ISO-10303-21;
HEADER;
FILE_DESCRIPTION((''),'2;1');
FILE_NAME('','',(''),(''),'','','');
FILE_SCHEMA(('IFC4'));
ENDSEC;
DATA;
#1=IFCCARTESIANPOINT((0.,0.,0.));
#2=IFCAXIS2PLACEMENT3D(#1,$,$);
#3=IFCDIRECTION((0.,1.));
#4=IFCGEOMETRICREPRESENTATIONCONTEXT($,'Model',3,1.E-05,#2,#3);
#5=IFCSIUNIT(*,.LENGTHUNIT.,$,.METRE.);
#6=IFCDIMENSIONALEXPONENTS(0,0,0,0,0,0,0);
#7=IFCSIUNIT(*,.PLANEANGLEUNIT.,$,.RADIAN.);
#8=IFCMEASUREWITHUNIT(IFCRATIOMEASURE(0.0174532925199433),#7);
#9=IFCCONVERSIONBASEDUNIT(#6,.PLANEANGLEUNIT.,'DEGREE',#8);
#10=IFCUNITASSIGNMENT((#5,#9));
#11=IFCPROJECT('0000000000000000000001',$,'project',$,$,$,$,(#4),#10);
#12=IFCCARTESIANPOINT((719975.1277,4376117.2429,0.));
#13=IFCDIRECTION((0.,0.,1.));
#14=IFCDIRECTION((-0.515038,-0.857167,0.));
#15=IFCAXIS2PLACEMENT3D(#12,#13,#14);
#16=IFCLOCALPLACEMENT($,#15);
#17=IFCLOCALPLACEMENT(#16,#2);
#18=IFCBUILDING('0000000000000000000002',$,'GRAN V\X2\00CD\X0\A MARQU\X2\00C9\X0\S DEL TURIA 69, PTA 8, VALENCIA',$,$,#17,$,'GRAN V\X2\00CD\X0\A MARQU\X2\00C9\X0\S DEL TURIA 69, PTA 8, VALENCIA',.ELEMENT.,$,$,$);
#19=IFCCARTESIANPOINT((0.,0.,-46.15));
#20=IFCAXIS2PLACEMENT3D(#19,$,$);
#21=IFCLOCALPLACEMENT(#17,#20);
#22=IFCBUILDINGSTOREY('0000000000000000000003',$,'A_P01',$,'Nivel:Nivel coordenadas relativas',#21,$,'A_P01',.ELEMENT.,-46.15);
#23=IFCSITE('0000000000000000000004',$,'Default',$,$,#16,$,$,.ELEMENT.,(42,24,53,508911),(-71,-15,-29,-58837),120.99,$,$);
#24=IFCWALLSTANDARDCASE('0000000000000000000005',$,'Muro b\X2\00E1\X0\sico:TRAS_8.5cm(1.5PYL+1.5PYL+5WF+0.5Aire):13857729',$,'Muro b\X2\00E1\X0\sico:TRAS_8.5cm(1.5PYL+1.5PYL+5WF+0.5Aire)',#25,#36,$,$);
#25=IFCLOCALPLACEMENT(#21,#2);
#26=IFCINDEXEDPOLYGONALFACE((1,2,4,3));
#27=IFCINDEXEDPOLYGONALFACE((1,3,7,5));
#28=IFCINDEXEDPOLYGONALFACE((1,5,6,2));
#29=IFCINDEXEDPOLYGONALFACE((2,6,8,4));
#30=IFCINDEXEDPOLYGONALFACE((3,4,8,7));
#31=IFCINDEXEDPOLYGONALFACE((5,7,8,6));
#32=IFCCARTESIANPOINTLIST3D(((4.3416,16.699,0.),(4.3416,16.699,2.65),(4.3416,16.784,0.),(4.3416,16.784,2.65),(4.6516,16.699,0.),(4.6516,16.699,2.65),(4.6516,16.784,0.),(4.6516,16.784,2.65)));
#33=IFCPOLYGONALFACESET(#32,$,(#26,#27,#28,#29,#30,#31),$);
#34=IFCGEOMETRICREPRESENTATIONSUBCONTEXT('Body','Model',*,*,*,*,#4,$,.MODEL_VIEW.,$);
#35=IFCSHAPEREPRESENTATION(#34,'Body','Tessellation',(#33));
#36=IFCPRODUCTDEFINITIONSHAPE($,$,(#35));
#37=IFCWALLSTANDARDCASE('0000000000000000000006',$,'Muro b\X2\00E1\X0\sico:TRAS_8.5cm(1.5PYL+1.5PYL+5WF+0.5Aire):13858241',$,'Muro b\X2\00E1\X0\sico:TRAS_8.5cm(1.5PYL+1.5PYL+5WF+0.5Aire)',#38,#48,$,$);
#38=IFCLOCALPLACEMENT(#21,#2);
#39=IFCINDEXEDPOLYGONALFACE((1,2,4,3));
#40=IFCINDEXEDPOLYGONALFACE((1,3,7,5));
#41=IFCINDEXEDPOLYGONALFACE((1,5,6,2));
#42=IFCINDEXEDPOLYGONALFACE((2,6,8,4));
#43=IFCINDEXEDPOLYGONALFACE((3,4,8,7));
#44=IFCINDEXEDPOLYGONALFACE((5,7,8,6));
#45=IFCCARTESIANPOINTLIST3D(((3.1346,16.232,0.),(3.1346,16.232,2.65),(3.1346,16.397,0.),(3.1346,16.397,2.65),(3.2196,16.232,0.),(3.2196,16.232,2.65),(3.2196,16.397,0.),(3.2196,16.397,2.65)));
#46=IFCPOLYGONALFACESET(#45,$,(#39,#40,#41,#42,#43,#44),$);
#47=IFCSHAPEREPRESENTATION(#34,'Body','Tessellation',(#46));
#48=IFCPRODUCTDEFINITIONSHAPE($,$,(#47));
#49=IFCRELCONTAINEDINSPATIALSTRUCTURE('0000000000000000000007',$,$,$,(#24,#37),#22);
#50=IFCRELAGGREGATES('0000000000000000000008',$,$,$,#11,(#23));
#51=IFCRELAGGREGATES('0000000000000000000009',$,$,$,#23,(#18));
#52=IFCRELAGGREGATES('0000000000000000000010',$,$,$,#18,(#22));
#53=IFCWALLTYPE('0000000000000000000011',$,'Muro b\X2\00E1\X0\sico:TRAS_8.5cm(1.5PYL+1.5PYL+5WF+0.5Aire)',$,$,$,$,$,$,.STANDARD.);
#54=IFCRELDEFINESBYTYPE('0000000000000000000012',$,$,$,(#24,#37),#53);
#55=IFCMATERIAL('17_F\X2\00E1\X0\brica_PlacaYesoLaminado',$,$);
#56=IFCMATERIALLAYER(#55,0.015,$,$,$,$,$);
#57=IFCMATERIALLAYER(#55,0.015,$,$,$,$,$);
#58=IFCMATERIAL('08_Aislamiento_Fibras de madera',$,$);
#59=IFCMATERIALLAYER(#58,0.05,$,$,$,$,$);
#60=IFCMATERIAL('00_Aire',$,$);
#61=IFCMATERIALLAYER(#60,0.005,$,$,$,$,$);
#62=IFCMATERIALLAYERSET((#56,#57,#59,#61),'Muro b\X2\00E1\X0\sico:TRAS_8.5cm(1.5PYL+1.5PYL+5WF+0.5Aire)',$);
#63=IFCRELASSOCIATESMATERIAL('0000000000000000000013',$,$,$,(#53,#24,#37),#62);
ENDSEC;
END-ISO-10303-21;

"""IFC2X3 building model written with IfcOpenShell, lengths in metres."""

from ifc_helpers import new_model, entity, si_unit, converted_unit, direction, frame, frame_2d, origin, place, context, subcontext, project, spatial, rectangle, extrude, material, layer, layer_set, layer_usage, type_object, element, save


model = new_model("IFC2X3")

# Units and contexts
model_context = context("Model", 3, precision=1e-05, world=origin(), true_north=direction((0.0, 1.0)))
body_context = subcontext(model_context, "Body", "Model", "MODEL_VIEW")
ifc_project = project(units=[si_unit("LENGTHUNIT", "METRE"), converted_unit("PLANEANGLEUNIT", "DEGREE", entity("IfcRatioMeasure", 0.0174532925199433), si_unit("PLANEANGLEUNIT", "RADIAN"), dimensions=[0, 0, 0, 0, 0, 0, 0])], contexts=[model_context])

# Site, building, storey
site_placement = place(None, frame((719975.1277, 4376117.2429, 0.0), z_axis=(0.0, 0.0, 1.0), x_axis=(-0.515038, -0.857167, 0.0)))
site = spatial("IfcSite", under=ifc_project, at=site_placement, Name="Default", CompositionType="ELEMENT", RefLatitude=(42, 24, 53, 508911), RefLongitude=(-71, -15, -29, -58837), RefElevation=120.99)
building_placement = place(site_placement, origin())
building = spatial("IfcBuilding", under=site, at=building_placement, Name="GRAN VÍA MARQUÉS DEL TURIA 69, PTA 8, VALENCIA", LongName="GRAN VÍA MARQUÉS DEL TURIA 69, PTA 8, VALENCIA", CompositionType="ELEMENT")
storey_placement = place(building_placement, frame((0.0, 0.0, -46.15)))
storey = spatial("IfcBuildingStorey", under=building, at=storey_placement, Name="A_P01", ObjectType="Nivel:Nivel coordenadas relativas", LongName="A_P01", CompositionType="ELEMENT", Elevation=-46.15)

# Shared definitions
ifc_material_1 = material(Name="08_Aislamiento_Fibras de madera")

# Walls
ifc_material_2 = material(Name="17_Fábrica_PlacaYesoLaminado")
ifc_layer_1 = layer(ifc_material_2, 0.015)
ifc_layer_2 = layer(ifc_material_2, 0.015)
ifc_layer_3 = layer(ifc_material_1, 0.05)
ifc_material_3 = material(Name="00_Aire")
ifc_layer_4 = layer(ifc_material_3, 0.005)
ifc_layer_set_1 = layer_set([ifc_layer_1, ifc_layer_2, ifc_layer_3, ifc_layer_4], Name="Muro básico:TRAS_8.5cm(1.5PYL+1.5PYL+5WF+0.5Aire)")
wall_type_1 = type_object("IfcWallType", Name="Muro básico:TRAS_8.5cm(1.5PYL+1.5PYL+5WF+0.5Aire)", PredefinedType="STANDARD", material=ifc_layer_set_1)
ifc_layer_usage_1 = layer_usage(ifc_layer_set_1, "AXIS2", "NEGATIVE", 0.0425)
wall_1_placement = place(storey_placement, frame((4.3416, 16.7415, 0.0)))
element("IfcWallStandardCase", 1, at=wall_1_placement, inside=storey, type_object=wall_type_1, material=ifc_layer_usage_1, Name="Muro básico:TRAS_8.5cm(1.5PYL+1.5PYL+5WF+0.5Aire):13857729", ObjectType="Muro básico:TRAS_8.5cm(1.5PYL+1.5PYL+5WF+0.5Aire)", context=body_context, shape_type="SweptSolid", body=[
    extrude(rectangle(XDim=0.31, YDim=0.085, at=frame_2d((0.155, 0.0), x_axis=(-1.0, 0.0))), origin(), (0.0, 0.0, 1.0), 2.65),
])
ifc_layer_usage_2 = layer_usage(ifc_layer_set_1, "AXIS2", "POSITIVE", -0.0425)
wall_2_placement = place(storey_placement, frame((3.1771, 16.232, 0.0), z_axis=(0.0, 0.0, 1.0), x_axis=(0.0, 1.0, 0.0)))
element("IfcWallStandardCase", 2, at=wall_2_placement, inside=storey, type_object=wall_type_1, material=ifc_layer_usage_2, Name="Muro básico:TRAS_8.5cm(1.5PYL+1.5PYL+5WF+0.5Aire):13858241", ObjectType="Muro básico:TRAS_8.5cm(1.5PYL+1.5PYL+5WF+0.5Aire)", context=body_context, shape_type="SweptSolid", body=[
    extrude(rectangle(XDim=0.165, YDim=0.085, at=frame_2d((0.0825, 0.0), x_axis=(-1.0, 0.0))), origin(), (0.0, 0.0, 1.0), 2.65),
])

save(model, "model.ifc")
